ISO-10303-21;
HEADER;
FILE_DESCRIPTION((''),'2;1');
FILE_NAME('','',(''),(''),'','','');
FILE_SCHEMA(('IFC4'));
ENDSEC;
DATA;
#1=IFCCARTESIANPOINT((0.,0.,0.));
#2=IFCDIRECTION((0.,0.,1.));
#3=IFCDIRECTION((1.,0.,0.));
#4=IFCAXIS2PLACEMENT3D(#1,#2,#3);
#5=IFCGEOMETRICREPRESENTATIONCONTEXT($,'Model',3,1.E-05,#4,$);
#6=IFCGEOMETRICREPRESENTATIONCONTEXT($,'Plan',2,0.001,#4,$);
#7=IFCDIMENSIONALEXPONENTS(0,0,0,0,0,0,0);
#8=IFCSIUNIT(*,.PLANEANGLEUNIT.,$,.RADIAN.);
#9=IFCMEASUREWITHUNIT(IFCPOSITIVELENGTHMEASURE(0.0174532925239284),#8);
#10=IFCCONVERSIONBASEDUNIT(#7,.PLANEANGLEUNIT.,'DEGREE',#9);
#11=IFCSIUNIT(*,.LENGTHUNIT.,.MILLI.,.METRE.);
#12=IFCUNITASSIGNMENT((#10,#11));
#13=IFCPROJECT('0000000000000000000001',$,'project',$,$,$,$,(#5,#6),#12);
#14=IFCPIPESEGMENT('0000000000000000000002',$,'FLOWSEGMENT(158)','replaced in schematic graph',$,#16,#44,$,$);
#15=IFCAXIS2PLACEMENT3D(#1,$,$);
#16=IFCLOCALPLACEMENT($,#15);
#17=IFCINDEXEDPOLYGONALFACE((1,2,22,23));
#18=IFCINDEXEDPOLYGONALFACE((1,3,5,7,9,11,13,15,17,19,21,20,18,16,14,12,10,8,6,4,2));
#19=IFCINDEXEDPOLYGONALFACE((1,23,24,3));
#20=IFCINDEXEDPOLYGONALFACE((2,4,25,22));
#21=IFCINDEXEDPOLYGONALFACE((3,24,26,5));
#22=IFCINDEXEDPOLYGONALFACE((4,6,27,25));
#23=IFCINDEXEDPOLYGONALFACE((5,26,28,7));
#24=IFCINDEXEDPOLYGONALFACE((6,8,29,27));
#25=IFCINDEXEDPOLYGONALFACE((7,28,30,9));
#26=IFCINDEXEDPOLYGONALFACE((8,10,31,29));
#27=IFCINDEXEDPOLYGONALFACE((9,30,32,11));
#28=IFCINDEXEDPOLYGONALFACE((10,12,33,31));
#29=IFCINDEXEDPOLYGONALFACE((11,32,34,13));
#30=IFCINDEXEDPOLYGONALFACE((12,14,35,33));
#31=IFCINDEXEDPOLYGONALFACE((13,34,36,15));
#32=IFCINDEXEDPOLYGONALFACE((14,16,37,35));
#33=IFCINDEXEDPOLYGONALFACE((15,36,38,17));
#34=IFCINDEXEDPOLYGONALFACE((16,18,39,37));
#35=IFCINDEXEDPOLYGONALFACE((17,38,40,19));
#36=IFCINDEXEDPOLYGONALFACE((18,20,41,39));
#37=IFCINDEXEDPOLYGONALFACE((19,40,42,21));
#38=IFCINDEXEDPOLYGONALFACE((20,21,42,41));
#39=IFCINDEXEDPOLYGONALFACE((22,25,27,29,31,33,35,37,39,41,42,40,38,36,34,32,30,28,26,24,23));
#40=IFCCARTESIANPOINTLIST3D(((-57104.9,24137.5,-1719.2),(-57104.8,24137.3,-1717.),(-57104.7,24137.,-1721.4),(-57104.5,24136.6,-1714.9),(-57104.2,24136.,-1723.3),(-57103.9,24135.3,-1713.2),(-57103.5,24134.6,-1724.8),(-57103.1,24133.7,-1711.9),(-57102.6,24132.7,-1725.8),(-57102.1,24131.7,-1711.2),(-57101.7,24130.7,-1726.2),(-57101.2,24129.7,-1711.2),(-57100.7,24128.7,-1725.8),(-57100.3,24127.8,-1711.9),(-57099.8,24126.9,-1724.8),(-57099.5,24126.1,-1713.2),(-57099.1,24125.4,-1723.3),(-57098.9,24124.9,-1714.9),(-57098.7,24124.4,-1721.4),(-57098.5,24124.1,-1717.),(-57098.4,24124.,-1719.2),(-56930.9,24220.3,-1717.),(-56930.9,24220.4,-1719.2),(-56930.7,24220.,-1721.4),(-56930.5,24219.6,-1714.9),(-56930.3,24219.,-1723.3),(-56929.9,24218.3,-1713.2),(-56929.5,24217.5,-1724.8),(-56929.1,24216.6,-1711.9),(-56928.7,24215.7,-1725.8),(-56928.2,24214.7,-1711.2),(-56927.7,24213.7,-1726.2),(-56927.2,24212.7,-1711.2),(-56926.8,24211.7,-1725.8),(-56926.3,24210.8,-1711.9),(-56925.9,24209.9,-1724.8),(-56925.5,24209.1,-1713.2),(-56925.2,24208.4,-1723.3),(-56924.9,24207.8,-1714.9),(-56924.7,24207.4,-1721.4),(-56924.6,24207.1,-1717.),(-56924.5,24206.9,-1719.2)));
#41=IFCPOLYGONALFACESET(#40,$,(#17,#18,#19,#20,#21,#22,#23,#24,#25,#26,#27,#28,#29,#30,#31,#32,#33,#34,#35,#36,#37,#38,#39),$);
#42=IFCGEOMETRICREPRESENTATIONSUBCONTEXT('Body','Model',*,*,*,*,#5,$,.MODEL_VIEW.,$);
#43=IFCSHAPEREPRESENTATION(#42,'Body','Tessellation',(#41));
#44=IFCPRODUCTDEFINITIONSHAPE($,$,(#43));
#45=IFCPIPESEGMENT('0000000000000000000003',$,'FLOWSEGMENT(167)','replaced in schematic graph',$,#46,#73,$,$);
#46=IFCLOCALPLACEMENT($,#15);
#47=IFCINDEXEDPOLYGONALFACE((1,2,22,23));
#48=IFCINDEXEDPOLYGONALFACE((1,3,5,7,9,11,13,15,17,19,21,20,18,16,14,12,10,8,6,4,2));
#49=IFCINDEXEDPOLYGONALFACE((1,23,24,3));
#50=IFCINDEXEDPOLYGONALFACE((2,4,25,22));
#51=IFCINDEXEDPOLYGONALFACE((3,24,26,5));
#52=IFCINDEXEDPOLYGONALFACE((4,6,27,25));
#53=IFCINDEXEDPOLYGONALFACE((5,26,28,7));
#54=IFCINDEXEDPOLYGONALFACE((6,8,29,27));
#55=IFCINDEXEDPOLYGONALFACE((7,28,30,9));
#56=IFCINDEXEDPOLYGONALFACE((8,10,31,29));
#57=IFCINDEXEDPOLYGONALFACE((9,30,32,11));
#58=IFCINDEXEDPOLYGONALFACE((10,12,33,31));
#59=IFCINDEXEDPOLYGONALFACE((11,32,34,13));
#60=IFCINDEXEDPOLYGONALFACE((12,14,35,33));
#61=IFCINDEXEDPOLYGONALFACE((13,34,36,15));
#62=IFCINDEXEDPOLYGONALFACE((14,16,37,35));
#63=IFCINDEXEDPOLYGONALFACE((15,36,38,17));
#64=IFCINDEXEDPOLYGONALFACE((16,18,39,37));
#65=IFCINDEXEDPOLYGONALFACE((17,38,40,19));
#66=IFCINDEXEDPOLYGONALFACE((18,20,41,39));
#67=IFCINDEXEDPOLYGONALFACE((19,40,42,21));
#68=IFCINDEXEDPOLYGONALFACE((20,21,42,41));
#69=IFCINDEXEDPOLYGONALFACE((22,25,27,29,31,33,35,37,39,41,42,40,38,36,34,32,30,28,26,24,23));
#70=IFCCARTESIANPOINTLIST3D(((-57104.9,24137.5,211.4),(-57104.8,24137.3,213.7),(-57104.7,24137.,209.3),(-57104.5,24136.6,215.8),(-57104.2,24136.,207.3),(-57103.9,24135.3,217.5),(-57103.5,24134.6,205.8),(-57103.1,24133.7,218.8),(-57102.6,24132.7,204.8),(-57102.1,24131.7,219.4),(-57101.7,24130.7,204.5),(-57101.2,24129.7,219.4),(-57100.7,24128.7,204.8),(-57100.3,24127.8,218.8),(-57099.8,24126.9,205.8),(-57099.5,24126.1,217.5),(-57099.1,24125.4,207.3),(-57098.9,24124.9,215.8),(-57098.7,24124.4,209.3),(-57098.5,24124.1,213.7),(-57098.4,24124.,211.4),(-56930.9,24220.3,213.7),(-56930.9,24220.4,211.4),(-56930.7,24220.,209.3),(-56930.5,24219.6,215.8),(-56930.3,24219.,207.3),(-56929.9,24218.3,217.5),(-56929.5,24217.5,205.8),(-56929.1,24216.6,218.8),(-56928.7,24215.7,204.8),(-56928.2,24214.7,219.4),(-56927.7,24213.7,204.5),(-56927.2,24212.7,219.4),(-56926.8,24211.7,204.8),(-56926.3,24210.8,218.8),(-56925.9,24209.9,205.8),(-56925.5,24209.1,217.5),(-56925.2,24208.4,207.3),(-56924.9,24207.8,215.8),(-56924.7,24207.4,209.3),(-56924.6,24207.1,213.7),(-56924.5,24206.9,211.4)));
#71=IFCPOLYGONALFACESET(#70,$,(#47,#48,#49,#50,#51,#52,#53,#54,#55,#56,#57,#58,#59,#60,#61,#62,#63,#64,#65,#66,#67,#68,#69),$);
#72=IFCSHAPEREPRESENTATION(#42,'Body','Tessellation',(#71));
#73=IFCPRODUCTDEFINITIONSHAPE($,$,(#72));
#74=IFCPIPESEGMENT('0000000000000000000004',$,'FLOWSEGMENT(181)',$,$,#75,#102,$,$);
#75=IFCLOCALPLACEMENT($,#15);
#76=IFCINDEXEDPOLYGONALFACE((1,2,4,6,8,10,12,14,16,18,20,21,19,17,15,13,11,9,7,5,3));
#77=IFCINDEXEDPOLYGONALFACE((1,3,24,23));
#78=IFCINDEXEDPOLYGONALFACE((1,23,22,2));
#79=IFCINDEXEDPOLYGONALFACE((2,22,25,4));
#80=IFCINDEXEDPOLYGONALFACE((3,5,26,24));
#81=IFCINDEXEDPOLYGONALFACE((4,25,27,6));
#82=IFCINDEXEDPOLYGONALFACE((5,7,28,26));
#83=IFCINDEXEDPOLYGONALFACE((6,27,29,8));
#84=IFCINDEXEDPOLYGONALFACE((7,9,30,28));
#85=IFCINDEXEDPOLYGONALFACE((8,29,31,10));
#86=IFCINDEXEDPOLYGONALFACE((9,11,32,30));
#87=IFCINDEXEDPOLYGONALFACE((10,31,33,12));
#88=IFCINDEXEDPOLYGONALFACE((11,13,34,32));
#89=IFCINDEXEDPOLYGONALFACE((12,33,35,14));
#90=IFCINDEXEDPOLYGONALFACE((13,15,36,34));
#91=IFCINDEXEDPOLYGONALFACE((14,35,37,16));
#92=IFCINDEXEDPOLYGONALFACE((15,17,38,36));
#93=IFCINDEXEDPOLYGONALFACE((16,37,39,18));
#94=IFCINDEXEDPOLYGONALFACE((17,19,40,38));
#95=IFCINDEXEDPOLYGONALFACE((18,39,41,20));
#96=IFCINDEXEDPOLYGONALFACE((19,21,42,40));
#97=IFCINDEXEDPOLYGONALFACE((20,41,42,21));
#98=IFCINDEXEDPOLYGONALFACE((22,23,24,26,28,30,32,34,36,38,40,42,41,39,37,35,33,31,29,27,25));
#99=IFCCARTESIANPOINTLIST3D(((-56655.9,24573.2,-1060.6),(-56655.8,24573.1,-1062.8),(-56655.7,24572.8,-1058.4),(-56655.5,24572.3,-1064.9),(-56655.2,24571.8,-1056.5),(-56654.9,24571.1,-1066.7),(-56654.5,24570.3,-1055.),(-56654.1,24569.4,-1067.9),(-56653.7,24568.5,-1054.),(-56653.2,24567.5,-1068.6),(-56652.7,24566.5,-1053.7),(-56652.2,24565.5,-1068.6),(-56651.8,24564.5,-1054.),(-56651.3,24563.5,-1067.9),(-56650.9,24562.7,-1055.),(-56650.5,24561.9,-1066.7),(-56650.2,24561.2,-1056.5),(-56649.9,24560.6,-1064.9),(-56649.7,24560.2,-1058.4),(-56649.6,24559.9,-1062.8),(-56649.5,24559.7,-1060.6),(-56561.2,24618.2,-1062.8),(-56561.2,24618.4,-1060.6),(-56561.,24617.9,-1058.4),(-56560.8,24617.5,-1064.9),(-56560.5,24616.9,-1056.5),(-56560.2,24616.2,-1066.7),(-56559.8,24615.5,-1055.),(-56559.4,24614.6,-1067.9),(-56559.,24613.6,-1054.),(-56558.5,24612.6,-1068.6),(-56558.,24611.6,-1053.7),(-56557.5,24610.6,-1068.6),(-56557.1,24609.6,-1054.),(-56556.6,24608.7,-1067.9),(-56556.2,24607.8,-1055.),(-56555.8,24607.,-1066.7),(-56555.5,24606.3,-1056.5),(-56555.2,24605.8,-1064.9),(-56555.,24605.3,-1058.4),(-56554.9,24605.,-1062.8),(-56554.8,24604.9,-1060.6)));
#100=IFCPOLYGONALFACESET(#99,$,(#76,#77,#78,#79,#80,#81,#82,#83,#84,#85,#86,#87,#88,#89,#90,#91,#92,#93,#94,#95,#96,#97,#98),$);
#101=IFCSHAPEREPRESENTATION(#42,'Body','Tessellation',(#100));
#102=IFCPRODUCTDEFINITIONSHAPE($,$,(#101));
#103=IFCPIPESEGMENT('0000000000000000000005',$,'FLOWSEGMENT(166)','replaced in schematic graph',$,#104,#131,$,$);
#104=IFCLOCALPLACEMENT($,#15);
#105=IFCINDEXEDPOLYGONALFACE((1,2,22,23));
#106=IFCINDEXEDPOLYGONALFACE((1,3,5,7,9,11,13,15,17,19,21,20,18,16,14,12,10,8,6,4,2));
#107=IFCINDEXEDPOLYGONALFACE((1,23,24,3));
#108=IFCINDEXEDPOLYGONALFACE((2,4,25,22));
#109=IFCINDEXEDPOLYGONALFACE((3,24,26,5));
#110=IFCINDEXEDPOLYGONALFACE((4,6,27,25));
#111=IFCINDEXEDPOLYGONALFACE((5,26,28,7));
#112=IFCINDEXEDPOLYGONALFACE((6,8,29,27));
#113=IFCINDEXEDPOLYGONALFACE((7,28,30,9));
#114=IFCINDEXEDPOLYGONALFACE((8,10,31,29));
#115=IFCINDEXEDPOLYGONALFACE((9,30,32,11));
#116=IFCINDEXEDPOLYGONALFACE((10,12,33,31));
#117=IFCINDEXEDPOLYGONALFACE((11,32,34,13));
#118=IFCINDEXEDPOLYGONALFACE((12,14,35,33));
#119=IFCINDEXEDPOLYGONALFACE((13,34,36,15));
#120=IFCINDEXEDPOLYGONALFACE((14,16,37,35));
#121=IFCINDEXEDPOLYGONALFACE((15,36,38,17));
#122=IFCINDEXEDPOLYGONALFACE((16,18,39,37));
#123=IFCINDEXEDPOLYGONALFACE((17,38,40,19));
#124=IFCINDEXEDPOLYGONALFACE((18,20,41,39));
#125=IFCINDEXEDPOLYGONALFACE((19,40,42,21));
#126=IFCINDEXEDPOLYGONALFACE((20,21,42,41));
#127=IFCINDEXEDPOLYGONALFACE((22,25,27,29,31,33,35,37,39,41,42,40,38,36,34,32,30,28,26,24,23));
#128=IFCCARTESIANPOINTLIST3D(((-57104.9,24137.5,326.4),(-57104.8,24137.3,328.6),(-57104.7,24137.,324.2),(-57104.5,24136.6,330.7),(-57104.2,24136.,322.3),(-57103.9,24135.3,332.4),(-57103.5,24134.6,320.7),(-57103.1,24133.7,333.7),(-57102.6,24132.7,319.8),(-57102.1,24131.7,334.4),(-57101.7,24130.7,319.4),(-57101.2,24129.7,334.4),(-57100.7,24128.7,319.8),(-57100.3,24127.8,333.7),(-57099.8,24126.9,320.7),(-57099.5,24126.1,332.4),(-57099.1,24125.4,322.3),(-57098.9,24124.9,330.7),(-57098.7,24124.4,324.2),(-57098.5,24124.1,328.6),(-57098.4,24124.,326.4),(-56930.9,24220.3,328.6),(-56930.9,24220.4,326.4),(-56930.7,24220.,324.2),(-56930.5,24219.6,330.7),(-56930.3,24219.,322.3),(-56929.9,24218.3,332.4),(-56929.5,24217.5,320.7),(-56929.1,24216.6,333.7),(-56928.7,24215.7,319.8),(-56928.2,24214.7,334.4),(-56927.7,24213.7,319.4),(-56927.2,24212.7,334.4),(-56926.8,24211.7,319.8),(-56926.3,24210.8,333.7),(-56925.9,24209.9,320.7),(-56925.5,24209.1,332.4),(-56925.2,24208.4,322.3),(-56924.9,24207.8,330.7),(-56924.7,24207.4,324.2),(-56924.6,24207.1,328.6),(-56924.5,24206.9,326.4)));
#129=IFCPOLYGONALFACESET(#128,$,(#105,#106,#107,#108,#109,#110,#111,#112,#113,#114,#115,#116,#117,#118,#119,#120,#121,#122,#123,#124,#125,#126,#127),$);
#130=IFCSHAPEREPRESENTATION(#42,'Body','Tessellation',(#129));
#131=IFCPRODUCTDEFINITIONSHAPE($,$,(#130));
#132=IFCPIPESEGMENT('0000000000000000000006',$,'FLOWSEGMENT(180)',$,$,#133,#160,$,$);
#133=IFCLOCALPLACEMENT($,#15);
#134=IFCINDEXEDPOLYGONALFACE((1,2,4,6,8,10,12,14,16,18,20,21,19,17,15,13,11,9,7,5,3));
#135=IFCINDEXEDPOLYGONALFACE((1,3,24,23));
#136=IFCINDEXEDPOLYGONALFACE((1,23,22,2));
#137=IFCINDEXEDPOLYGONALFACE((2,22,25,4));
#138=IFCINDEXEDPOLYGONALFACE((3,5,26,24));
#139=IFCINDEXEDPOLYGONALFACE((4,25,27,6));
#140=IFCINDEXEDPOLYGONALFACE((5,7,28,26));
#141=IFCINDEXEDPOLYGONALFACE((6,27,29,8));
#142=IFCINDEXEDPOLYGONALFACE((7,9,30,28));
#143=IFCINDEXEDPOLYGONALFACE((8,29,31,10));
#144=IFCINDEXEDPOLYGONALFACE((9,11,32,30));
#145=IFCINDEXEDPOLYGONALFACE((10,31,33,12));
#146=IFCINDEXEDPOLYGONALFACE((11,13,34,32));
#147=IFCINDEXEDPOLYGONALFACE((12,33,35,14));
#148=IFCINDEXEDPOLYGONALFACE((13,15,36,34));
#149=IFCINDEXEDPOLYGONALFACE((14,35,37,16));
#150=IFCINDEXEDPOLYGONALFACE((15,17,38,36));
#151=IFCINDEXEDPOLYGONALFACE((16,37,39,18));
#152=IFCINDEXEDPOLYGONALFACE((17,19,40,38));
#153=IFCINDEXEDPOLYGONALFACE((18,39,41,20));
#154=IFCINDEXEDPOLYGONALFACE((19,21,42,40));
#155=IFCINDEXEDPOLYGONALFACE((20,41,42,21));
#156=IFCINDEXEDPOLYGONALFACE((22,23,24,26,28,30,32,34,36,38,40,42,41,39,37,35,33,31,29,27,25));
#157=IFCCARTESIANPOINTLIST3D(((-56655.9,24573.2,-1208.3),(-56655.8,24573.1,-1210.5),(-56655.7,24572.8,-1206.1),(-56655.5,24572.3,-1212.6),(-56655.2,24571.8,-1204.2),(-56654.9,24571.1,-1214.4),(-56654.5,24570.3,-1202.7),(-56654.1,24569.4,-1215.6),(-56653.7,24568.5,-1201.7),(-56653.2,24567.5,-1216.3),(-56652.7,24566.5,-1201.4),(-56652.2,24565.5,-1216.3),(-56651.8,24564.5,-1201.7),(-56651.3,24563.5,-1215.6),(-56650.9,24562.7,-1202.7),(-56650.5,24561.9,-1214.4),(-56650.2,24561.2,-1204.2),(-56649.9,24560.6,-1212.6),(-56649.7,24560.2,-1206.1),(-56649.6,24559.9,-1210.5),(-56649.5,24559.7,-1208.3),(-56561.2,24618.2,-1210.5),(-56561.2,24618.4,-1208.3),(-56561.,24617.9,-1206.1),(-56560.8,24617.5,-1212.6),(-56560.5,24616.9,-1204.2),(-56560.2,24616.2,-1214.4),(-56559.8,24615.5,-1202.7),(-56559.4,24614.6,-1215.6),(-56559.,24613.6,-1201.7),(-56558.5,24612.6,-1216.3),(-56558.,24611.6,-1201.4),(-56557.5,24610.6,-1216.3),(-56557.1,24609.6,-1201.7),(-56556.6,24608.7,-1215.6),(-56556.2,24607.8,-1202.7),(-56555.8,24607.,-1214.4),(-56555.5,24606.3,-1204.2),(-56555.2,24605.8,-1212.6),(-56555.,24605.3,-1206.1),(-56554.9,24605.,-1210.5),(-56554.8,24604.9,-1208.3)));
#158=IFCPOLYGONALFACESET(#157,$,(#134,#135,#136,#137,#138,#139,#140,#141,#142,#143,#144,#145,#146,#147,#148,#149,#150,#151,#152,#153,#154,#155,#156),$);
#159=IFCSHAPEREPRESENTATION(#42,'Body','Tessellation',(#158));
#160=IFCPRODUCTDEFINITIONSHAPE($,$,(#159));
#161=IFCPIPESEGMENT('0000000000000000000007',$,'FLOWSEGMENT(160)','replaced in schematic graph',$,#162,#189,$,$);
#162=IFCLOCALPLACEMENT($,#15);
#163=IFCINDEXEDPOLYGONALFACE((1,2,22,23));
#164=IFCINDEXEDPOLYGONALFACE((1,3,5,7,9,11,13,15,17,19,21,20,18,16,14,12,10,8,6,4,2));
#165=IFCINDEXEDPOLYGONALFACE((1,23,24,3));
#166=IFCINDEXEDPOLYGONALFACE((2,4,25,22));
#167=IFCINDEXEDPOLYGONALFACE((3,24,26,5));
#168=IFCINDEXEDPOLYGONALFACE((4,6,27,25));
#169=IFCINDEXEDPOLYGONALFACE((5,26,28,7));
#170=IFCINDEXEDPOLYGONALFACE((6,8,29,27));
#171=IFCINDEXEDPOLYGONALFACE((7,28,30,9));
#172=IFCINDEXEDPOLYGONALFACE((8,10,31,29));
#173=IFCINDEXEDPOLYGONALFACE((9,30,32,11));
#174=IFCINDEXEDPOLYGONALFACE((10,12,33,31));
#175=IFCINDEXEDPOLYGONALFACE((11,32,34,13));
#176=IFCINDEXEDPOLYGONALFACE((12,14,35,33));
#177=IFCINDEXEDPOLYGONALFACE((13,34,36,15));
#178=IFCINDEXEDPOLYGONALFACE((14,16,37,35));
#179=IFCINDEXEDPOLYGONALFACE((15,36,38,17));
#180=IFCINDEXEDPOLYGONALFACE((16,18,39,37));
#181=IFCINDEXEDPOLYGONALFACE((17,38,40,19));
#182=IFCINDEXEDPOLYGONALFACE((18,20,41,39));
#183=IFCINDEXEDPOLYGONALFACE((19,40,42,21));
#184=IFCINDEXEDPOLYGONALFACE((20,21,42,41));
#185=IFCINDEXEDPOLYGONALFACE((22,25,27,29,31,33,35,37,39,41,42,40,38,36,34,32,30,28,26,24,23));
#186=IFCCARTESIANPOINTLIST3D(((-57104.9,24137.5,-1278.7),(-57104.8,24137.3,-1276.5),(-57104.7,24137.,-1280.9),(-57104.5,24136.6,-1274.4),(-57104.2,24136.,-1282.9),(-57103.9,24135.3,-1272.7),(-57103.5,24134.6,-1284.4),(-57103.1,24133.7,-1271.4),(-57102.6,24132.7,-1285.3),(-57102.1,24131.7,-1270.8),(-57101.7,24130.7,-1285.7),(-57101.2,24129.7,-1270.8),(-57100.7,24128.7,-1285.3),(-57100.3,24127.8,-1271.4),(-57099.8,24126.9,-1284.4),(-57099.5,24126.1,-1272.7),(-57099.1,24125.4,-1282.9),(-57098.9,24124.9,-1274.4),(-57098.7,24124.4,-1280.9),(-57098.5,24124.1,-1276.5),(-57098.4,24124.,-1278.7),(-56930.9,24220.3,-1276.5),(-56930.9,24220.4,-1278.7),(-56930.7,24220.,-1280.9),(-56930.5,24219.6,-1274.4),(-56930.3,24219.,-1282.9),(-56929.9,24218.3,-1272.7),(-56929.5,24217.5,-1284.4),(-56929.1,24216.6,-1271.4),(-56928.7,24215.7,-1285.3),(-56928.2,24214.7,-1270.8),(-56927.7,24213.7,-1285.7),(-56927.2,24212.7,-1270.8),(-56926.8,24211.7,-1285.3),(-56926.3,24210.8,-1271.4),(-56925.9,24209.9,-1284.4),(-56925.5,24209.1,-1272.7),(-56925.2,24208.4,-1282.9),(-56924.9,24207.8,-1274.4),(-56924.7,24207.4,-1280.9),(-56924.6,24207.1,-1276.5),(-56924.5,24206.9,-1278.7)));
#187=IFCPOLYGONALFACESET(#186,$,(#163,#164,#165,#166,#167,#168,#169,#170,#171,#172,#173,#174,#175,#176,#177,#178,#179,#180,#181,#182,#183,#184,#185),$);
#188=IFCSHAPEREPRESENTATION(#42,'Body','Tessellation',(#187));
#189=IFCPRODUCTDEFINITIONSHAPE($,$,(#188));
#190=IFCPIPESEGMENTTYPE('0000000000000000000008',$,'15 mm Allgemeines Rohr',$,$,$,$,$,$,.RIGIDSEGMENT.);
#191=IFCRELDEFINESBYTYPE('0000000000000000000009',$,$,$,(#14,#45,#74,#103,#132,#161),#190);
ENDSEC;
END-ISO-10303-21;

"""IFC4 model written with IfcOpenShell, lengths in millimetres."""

from ifc_helpers import new_model, entity, si_unit, converted_unit, frame, frame_2d, origin, origin_with_axes, place, context, subcontext, project, circle, extrude, source, transform, mapped, type_object, element, save


model = new_model("IFC4")

# Units and contexts
model_context = context("Model", 3, precision=1e-05, world=origin_with_axes())
plan_context = context("Plan", 2, precision=0.001, world=origin_with_axes())
body_context = subcontext(model_context, "Body", "Model", "MODEL_VIEW")
ifc_project = project(units=[converted_unit("PLANEANGLEUNIT", "DEGREE", entity("IfcPositiveLengthMeasure", 0.0174532925239284), si_unit("PLANEANGLEUNIT", "RADIAN"), dimensions=[0, 0, 0, 0, 0, 0, 0]), si_unit("LENGTHUNIT", "METRE", prefix="MILLI")], contexts=[model_context, plan_context])

# Pipe segments
pipe_segment_type_1 = type_object("IfcPipeSegmentType", Name="15 mm Allgemeines Rohr", PredefinedType="RIGIDSEGMENT")
shared_shape = source(origin(), body_context, "Body", "SweptSolid", [
    extrude(circle(Radius=7.5, at=frame_2d((7.5, 7.5), x_axis=(1.0, 0.0))), frame((0.0, -7.5, -7.5), z_axis=(1.0, 0.0, 0.0), x_axis=(0.0, 1.0, 0.0)), (0.0, 0.0, 1.0), 1.0),
])
placement_1 = place(None, origin_with_axes())
placement_2 = place(placement_1, origin_with_axes())
placement_3 = place(placement_2, frame((0.0, 0.0, -3400.0), z_axis=(0.0, 0.0, 1.0), x_axis=(1.0, 0.0, 0.0)))
placement_4 = place(placement_3, frame((-57101.7, 24130.7, 1681.3), z_axis=(-0.430461, 0.902609, 0.0), x_axis=(0.902609, 0.430461, 0.0)))
element("IfcPipeSegment", 1, at=placement_4, type_object=pipe_segment_type_1, Name="FLOWSEGMENT(158)", Description="replaced in schematic graph", context=body_context, shape_type="MappedRepresentation", body=[
    mapped(shared_shape, transform((0.0, 0.0, 0.0), x_axis=(1.0, 0.0, 0.0), y_axis=(0.0, 1.0, 0.0), z_axis=(0.0, 0.0, 1.0), scale=192.697716, scale2=1.0, scale3=1.0, uniform=False)),
])
placement_5 = place(placement_3, frame((-57101.7, 24130.7, 3612.0), z_axis=(-0.430461, 0.902609, 0.0), x_axis=(0.902609, 0.430461, 0.0)))
element("IfcPipeSegment", 2, at=placement_5, type_object=pipe_segment_type_1, Name="FLOWSEGMENT(167)", Description="replaced in schematic graph", context=body_context, shape_type="MappedRepresentation", body=[
    mapped(shared_shape, transform((0.0, 0.0, 0.0), x_axis=(1.0, 0.0, 0.0), y_axis=(0.0, 1.0, 0.0), z_axis=(0.0, 0.0, 1.0), scale=192.697716, scale2=1.0, scale3=1.0, uniform=False)),
])
pipe_segment_1_placement = place(placement_3, frame((-56558.0, 24611.6, 2338.8), z_axis=(-0.430461, 0.902609, 0.0), x_axis=(-0.902609, -0.430461, 0.0)))
element("IfcPipeSegment", 3, at=pipe_segment_1_placement, type_object=pipe_segment_type_1, Name="FLOWSEGMENT(181)", context=body_context, shape_type="MappedRepresentation", body=[
    mapped(shared_shape, transform((0.0, 0.0, 0.0), x_axis=(1.0, 0.0, 0.0), y_axis=(0.0, 1.0, 0.0), z_axis=(0.0, 0.0, 1.0), scale=104.898581, scale2=1.0, scale3=1.0, uniform=False)),
])
placement_6 = place(placement_3, frame((-57101.7, 24130.7, 3726.9), z_axis=(-0.430461, 0.902609, 0.0), x_axis=(0.902609, 0.430461, 0.0)))
element("IfcPipeSegment", 4, at=placement_6, type_object=pipe_segment_type_1, Name="FLOWSEGMENT(166)", Description="replaced in schematic graph", context=body_context, shape_type="MappedRepresentation", body=[
    mapped(shared_shape, transform((0.0, 0.0, 0.0), x_axis=(1.0, 0.0, 0.0), y_axis=(0.0, 1.0, 0.0), z_axis=(0.0, 0.0, 1.0), scale=192.697716, scale2=1.0, scale3=1.0, uniform=False)),
])
pipe_segment_2_placement = place(placement_3, frame((-56558.0, 24611.6, 2191.1), z_axis=(-0.430461, 0.902609, 0.0), x_axis=(-0.902609, -0.430461, 0.0)))
element("IfcPipeSegment", 5, at=pipe_segment_2_placement, type_object=pipe_segment_type_1, Name="FLOWSEGMENT(180)", context=body_context, shape_type="MappedRepresentation", body=[
    mapped(shared_shape, transform((0.0, 0.0, 0.0), x_axis=(1.0, 0.0, 0.0), y_axis=(0.0, 1.0, 0.0), z_axis=(0.0, 0.0, 1.0), scale=104.898581, scale2=1.0, scale3=1.0, uniform=False)),
])
placement_7 = place(placement_3, frame((-57101.7, 24130.7, 2121.8), z_axis=(-0.430461, 0.902609, 0.0), x_axis=(0.902609, 0.430461, 0.0)))
element("IfcPipeSegment", 6, at=placement_7, type_object=pipe_segment_type_1, Name="FLOWSEGMENT(160)", Description="replaced in schematic graph", context=body_context, shape_type="MappedRepresentation", body=[
    mapped(shared_shape, transform((0.0, 0.0, 0.0), x_axis=(1.0, 0.0, 0.0), y_axis=(0.0, 1.0, 0.0), z_axis=(0.0, 0.0, 1.0), scale=192.697716, scale2=1.0, scale3=1.0, uniform=False)),
])

save(model, "model.ifc")
